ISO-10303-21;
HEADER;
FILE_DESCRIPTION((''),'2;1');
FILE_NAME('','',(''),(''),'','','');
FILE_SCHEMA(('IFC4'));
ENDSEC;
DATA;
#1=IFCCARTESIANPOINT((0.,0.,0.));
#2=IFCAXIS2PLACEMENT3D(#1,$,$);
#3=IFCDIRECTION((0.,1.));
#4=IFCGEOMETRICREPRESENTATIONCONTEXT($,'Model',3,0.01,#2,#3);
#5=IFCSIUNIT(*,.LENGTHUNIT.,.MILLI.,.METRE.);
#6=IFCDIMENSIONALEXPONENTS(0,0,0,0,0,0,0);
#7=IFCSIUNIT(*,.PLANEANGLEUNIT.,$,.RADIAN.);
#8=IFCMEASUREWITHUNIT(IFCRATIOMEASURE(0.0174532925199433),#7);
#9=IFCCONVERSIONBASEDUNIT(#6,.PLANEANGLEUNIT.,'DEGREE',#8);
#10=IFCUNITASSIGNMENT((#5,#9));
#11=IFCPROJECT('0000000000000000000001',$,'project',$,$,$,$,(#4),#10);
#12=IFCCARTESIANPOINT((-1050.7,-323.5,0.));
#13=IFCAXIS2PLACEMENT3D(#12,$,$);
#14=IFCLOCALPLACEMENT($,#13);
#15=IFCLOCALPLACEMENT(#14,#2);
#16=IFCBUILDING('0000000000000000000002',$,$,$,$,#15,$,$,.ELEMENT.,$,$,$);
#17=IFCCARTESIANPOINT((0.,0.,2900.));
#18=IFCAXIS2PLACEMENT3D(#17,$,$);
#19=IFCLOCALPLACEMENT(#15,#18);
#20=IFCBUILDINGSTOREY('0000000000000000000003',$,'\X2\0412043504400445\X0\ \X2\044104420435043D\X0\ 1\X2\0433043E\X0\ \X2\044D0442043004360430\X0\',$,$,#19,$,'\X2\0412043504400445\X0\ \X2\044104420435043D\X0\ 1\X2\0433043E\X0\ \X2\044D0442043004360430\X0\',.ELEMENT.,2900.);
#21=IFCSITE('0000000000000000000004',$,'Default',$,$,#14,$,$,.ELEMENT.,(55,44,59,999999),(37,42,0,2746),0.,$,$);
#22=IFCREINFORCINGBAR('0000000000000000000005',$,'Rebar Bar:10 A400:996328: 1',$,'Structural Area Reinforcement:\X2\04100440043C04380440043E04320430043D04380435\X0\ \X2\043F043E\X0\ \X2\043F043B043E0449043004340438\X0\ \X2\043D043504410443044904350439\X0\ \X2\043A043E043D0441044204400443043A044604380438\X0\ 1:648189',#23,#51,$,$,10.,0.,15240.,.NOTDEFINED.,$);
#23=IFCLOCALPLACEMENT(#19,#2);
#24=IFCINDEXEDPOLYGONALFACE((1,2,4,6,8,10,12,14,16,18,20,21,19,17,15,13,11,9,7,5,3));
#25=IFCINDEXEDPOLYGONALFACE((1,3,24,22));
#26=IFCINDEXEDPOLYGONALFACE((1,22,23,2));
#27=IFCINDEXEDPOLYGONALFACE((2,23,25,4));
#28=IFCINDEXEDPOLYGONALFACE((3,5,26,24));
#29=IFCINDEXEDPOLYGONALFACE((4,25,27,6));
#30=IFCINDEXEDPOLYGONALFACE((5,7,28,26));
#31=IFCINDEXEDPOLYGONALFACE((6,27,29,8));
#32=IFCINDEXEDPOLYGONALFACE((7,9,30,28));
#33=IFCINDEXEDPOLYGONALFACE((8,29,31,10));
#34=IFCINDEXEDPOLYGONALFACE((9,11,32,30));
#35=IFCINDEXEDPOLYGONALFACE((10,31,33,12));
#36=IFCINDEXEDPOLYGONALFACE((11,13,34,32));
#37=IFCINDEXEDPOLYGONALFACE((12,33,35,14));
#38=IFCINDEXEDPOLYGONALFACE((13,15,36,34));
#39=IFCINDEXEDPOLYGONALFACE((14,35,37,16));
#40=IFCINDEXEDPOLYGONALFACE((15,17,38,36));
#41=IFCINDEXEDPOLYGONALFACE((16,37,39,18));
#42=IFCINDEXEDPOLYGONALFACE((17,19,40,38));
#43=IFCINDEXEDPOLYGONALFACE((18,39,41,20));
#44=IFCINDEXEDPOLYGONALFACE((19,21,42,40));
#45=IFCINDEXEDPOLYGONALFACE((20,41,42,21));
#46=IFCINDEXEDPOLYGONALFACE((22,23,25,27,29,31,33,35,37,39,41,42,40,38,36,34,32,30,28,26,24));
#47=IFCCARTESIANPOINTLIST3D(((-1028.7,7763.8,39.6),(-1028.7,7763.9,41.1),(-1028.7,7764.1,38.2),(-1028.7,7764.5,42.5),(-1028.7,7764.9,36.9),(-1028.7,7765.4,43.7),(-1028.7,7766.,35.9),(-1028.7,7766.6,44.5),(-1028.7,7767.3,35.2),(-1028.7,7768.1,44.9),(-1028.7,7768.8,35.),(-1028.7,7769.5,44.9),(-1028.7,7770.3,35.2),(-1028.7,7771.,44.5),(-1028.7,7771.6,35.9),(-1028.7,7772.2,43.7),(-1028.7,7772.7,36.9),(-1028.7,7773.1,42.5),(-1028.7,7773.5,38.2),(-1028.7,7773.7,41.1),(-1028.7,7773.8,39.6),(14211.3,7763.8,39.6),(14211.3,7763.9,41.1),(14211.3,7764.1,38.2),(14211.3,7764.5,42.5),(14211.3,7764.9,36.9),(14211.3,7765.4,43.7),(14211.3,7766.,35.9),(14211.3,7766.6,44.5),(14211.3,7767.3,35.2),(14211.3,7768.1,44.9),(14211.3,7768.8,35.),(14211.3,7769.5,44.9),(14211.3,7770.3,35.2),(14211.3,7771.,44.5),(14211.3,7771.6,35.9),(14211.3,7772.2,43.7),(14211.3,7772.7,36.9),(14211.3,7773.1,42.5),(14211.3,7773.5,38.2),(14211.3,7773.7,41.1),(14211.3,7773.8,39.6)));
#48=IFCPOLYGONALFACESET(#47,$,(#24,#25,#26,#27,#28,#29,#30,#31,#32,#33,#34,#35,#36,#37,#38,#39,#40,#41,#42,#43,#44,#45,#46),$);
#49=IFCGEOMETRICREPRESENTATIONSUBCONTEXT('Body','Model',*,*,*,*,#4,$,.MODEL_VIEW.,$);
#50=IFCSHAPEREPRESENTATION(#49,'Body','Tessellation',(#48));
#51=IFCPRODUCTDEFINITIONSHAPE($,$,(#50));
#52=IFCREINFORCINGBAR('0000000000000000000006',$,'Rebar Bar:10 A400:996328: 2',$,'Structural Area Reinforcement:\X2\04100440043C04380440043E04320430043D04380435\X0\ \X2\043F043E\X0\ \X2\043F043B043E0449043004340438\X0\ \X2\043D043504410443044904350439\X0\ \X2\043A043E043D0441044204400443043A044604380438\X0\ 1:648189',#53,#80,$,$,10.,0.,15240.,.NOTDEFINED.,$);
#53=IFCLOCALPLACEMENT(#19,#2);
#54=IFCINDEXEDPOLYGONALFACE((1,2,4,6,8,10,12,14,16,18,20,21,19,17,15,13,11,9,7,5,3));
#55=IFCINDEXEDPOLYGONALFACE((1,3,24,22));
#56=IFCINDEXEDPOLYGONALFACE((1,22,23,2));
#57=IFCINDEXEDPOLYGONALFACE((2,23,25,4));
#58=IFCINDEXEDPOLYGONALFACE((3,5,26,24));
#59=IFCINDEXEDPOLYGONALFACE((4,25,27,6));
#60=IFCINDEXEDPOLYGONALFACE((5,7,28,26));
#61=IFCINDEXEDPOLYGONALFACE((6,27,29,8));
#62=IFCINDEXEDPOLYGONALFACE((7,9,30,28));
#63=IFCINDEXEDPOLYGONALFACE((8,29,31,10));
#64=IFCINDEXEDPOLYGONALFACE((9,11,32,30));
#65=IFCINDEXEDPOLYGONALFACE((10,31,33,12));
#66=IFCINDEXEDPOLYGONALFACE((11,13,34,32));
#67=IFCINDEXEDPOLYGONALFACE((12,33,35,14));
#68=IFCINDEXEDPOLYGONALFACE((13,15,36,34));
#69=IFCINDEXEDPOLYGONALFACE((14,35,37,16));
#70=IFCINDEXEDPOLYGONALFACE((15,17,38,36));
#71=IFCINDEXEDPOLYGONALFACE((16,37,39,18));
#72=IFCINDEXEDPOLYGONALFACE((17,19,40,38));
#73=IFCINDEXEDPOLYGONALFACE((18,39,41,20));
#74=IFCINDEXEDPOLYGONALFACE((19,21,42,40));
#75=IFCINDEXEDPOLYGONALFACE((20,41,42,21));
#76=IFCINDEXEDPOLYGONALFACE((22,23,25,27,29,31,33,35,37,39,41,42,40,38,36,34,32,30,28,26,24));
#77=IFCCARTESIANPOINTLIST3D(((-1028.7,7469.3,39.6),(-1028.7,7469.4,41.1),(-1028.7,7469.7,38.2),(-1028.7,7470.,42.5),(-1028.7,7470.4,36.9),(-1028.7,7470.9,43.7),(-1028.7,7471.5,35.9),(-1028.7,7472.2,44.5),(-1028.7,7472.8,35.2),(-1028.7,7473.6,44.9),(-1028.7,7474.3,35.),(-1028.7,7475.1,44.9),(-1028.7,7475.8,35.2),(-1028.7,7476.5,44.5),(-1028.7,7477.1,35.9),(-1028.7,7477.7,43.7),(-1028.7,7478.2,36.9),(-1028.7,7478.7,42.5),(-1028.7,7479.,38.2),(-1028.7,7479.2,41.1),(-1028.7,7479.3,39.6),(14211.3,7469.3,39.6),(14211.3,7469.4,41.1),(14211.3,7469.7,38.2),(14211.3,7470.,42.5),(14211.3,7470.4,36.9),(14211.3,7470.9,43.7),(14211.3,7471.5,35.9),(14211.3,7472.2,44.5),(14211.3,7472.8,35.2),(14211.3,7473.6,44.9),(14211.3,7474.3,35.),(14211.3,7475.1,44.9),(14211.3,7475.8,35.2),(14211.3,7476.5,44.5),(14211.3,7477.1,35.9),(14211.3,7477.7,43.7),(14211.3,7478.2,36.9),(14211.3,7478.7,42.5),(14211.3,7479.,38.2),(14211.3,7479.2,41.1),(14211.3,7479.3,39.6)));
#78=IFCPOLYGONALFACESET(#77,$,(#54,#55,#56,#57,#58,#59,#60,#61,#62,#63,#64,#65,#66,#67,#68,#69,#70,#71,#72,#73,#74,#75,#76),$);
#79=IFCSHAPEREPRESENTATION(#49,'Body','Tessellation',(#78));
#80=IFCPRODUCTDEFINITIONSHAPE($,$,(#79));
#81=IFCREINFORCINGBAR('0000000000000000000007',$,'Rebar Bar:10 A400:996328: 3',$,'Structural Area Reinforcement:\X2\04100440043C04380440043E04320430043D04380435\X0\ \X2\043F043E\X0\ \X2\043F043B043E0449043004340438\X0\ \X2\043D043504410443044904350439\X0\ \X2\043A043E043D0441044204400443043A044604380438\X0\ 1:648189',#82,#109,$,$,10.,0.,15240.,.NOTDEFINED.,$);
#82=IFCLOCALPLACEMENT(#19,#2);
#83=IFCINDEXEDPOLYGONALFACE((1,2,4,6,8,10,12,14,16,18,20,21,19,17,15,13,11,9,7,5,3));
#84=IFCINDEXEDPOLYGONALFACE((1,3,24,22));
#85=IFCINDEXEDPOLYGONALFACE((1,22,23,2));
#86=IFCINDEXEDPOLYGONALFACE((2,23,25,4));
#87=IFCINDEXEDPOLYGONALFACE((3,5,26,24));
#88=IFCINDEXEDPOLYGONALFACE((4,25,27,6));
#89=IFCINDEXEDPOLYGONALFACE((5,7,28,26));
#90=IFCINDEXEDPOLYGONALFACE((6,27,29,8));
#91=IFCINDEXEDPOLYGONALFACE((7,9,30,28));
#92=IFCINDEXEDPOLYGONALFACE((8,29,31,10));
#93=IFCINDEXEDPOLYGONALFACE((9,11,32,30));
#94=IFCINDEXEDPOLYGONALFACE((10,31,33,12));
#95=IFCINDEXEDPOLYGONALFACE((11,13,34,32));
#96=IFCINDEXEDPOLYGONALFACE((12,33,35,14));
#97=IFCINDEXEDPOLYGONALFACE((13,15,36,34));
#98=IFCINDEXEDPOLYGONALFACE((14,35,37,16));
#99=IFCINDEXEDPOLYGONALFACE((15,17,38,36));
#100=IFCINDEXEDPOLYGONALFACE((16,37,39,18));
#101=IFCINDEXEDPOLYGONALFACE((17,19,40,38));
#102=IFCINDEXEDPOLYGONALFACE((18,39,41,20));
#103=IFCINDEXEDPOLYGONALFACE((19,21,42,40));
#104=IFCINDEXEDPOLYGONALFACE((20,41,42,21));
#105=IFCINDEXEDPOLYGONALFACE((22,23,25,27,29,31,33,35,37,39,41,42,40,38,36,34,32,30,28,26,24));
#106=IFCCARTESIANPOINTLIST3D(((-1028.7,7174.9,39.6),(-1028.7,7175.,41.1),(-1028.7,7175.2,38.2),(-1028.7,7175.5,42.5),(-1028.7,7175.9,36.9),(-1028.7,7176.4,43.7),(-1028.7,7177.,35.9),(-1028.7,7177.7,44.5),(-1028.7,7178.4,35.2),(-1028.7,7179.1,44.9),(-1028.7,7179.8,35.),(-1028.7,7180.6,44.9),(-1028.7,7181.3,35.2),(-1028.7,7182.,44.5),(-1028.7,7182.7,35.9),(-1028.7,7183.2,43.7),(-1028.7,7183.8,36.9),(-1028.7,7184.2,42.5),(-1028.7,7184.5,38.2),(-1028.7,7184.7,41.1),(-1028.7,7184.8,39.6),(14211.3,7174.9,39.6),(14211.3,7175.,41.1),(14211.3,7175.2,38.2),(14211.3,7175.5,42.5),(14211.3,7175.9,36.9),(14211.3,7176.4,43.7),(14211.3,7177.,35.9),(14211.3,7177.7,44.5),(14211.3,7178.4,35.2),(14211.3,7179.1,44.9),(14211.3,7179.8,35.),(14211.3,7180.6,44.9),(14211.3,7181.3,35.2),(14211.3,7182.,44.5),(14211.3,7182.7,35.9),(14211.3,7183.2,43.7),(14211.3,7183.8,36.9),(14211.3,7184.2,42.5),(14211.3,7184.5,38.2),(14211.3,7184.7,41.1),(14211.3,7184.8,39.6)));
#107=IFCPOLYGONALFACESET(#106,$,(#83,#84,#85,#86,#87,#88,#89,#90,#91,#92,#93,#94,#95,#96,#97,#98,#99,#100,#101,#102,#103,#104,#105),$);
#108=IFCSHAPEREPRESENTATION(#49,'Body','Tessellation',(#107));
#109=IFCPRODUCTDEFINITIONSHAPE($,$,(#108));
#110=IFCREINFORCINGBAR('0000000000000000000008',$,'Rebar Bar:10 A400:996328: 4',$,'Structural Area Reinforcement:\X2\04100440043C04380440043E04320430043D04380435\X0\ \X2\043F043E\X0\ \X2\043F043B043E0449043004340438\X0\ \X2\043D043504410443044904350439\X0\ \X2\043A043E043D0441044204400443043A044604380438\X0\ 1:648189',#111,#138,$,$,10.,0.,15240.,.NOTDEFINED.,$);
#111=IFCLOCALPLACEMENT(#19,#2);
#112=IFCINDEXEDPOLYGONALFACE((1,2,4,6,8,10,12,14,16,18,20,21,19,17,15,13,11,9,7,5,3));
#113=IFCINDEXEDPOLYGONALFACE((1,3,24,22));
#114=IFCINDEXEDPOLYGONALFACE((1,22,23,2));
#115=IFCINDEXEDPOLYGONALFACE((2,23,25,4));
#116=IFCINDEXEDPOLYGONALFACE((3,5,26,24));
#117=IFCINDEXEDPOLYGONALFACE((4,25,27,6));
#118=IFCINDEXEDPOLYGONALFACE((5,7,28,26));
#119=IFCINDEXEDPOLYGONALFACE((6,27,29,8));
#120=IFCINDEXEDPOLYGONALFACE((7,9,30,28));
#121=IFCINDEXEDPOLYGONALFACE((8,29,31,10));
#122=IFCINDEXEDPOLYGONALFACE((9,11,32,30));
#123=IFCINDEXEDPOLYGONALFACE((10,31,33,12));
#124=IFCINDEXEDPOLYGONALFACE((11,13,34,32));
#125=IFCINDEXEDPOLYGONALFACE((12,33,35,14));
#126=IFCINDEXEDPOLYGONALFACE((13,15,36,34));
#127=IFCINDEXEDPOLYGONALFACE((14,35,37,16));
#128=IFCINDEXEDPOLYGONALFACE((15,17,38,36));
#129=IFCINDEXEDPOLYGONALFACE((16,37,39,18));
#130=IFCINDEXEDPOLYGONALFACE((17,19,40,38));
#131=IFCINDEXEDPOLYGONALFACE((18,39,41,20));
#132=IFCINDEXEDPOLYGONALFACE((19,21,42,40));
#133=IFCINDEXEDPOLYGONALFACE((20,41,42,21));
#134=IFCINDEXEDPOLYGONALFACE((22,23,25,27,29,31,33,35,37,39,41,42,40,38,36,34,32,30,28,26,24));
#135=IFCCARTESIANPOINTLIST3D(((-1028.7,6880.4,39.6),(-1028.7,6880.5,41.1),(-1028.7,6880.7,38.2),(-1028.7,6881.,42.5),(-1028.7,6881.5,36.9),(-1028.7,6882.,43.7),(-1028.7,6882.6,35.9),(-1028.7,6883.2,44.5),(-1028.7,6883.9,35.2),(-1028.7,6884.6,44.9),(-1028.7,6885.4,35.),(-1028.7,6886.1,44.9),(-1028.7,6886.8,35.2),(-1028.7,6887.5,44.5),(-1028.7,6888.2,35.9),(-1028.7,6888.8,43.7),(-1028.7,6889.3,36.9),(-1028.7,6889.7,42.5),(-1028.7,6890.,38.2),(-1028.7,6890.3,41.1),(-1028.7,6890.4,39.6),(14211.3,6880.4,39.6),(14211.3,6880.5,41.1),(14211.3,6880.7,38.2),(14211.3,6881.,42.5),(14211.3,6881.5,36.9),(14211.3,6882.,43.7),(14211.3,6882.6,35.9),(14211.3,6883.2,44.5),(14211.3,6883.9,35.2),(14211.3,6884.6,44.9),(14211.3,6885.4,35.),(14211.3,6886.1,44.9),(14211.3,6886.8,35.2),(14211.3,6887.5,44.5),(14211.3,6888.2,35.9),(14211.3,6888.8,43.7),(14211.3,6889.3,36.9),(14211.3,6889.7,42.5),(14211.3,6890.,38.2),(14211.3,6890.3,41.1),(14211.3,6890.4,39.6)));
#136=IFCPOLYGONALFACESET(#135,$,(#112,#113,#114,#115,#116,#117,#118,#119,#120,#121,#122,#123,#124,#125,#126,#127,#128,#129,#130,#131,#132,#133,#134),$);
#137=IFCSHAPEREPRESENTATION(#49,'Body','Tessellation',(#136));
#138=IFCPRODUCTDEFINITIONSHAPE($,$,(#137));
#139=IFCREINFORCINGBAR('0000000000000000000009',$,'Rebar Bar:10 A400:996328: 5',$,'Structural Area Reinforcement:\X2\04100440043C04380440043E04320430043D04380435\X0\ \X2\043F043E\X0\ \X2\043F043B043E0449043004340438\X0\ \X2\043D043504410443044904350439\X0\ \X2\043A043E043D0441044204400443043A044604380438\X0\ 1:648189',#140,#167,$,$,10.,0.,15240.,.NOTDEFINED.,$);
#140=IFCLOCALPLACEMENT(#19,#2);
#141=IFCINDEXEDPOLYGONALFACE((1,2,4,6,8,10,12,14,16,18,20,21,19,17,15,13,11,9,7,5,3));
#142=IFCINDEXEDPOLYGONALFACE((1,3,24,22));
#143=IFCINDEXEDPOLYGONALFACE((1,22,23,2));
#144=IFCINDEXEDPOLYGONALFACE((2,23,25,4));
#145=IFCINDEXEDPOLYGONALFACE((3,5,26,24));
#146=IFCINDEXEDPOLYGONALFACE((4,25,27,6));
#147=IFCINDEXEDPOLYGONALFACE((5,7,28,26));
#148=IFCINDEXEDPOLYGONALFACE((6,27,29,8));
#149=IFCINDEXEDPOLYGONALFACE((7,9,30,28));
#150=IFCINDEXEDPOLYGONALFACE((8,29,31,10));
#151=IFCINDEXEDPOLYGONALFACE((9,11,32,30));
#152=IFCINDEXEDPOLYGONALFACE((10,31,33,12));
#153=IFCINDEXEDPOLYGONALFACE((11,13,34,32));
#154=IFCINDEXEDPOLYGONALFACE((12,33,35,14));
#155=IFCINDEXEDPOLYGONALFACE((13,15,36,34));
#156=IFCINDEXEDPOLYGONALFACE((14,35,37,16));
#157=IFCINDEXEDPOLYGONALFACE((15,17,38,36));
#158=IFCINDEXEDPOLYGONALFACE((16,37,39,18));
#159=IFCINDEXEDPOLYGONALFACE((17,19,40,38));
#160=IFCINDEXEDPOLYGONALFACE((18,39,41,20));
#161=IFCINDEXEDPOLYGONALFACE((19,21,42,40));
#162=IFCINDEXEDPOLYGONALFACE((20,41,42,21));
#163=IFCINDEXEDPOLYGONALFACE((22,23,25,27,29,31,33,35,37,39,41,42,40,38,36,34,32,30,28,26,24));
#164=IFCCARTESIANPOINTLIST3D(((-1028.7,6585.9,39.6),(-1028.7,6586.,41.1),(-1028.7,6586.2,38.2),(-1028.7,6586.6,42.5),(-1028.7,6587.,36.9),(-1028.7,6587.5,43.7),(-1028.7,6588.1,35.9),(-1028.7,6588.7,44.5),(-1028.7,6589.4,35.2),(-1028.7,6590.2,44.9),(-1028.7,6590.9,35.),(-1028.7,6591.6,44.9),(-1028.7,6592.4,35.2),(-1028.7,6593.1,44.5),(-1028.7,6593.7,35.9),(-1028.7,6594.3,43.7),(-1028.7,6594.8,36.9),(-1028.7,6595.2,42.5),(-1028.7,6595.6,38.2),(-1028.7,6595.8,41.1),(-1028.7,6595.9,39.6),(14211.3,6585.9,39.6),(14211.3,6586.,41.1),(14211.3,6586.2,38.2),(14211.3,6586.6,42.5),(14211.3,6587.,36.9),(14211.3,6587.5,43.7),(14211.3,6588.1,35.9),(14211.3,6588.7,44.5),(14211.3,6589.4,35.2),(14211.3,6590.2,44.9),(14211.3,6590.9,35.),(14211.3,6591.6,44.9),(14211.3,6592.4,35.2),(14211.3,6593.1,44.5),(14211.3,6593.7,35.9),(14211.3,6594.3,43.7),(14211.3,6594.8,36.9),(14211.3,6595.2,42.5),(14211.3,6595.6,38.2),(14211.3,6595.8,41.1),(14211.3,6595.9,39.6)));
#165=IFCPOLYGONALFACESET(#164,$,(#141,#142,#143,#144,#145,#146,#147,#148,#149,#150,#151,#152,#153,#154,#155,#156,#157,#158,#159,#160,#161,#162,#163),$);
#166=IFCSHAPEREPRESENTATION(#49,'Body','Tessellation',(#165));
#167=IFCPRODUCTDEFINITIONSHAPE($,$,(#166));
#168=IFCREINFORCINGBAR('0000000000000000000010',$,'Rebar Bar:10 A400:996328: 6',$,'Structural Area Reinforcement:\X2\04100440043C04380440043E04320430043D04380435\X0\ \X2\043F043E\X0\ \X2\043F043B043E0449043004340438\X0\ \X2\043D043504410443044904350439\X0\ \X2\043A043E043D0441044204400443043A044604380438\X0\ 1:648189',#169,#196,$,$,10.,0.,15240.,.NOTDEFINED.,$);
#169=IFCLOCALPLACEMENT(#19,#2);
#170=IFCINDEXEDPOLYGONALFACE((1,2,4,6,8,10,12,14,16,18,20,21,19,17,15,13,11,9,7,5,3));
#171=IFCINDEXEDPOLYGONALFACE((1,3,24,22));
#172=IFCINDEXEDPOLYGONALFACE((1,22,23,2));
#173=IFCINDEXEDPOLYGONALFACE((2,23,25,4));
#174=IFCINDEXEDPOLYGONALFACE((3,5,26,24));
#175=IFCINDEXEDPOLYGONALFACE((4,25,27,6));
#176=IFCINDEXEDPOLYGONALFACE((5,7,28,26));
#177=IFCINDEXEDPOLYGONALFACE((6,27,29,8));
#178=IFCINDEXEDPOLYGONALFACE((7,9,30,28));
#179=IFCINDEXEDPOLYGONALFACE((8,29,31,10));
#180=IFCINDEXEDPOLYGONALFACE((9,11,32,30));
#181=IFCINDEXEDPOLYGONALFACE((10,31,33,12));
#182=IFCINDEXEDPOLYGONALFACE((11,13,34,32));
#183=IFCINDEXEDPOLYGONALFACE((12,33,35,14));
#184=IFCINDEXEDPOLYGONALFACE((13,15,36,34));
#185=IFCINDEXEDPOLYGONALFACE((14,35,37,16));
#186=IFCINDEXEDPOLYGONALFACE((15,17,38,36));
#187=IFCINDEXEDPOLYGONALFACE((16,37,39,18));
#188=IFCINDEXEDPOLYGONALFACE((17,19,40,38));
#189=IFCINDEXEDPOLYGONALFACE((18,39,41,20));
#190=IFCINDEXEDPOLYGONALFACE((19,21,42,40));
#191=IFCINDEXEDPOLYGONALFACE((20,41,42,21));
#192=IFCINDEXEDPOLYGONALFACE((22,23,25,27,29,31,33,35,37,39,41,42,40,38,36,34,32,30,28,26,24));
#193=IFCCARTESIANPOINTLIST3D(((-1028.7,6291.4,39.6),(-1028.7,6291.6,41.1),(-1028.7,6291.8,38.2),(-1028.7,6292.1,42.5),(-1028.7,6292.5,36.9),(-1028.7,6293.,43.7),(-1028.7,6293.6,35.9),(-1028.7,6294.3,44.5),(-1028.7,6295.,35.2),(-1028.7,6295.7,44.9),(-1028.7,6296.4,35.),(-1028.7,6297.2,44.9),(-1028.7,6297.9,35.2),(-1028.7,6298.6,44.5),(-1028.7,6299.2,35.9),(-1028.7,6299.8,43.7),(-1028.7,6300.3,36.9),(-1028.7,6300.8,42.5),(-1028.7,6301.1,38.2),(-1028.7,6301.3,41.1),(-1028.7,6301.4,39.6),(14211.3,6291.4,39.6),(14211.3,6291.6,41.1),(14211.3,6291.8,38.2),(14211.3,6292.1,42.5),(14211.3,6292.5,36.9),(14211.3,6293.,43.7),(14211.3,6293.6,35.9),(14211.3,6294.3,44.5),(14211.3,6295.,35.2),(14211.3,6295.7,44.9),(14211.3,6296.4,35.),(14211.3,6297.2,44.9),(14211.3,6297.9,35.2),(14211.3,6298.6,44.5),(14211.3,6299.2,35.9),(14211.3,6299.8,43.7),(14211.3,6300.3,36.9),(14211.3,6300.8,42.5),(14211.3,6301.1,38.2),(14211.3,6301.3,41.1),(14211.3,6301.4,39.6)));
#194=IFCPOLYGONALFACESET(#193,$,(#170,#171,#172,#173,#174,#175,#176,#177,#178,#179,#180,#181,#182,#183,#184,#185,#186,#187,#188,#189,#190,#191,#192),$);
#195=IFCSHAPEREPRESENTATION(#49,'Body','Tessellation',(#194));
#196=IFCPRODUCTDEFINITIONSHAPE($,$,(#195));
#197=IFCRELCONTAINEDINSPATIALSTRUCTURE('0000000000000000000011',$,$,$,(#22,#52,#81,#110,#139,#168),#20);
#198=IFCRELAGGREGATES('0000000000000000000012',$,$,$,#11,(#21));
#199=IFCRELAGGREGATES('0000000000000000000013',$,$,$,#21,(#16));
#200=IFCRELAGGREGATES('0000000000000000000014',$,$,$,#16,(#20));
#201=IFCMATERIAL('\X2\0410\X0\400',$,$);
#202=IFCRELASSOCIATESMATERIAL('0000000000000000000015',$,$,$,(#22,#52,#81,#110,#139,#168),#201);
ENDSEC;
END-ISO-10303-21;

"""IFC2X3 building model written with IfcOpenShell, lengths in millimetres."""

from ifc_helpers import new_model, entity, si_unit, converted_unit, direction, frame, origin, place, context, subcontext, project, spatial, material, element, save


model = new_model("IFC2X3")

# Units and contexts
model_context = context("Model", 3, precision=0.01, world=origin(), true_north=direction((0.0, 1.0)))
body_context = subcontext(model_context, "Body", "Model", "MODEL_VIEW")
ifc_project = project(units=[si_unit("LENGTHUNIT", "METRE", prefix="MILLI"), converted_unit("PLANEANGLEUNIT", "DEGREE", entity("IfcRatioMeasure", 0.0174532925199433), si_unit("PLANEANGLEUNIT", "RADIAN"), dimensions=[0, 0, 0, 0, 0, 0, 0])], contexts=[model_context])

# Site, building, storey
site_placement = place(None, frame((-1050.7, -323.5, 0.0)))
site = spatial("IfcSite", under=ifc_project, at=site_placement, Name="Default", CompositionType="ELEMENT", RefLatitude=(55, 44, 59, 999999), RefLongitude=(37, 42, 0, 2746), RefElevation=0.0)
building_placement = place(site_placement, origin())
building = spatial("IfcBuilding", under=site, at=building_placement, CompositionType="ELEMENT")
storey_placement = place(building_placement, frame((0.0, 0.0, 2900.0)))
storey = spatial("IfcBuildingStorey", under=building, at=storey_placement, Name="Верх стен 1го этажа", LongName="Верх стен 1го этажа", CompositionType="ELEMENT", Elevation=2900.0)

# Reinforcing bars
ifc_material = material(Name="А400")
reinforcing_bar_1_placement = place(storey_placement, origin())
element("IfcReinforcingBar", 1, at=reinforcing_bar_1_placement, inside=storey, material=ifc_material, Name="Rebar Bar:10 A400:996328: 1", ObjectType="Structural Area Reinforcement:Армирование по площади несущей конструкции 1:648189", BarLength=15240.0, BarRole="NOTDEFINED", CrossSectionArea=0.0, NominalDiameter=10.0, context=body_context, shape_type="AdvancedSweptSolid", body=[
    entity("IfcSweptDiskSolid", entity("IfcCompositeCurve", [entity("IfcCompositeCurveSegment", "CONTINUOUS", True, entity("IfcPolyline", [entity("IfcCartesianPoint", [14211.3, 7768.8, 40.0]), entity("IfcCartesianPoint", [-1028.7, 7768.8, 40.0])]))], False), 5.0, None, 0.0, 1.0),
])
reinforcing_bar_2_placement = place(storey_placement, origin())
element("IfcReinforcingBar", 2, at=reinforcing_bar_2_placement, inside=storey, material=ifc_material, Name="Rebar Bar:10 A400:996328: 2", ObjectType="Structural Area Reinforcement:Армирование по площади несущей конструкции 1:648189", BarLength=15240.0, BarRole="NOTDEFINED", CrossSectionArea=0.0, NominalDiameter=10.0, context=body_context, shape_type="AdvancedSweptSolid", body=[
    entity("IfcSweptDiskSolid", entity("IfcCompositeCurve", [entity("IfcCompositeCurveSegment", "CONTINUOUS", True, entity("IfcPolyline", [entity("IfcCartesianPoint", [14211.3, 7474.3, 40.0]), entity("IfcCartesianPoint", [-1028.7, 7474.3, 40.0])]))], False), 5.0, None, 0.0, 1.0),
])
reinforcing_bar_3_placement = place(storey_placement, origin())
element("IfcReinforcingBar", 3, at=reinforcing_bar_3_placement, inside=storey, material=ifc_material, Name="Rebar Bar:10 A400:996328: 3", ObjectType="Structural Area Reinforcement:Армирование по площади несущей конструкции 1:648189", BarLength=15240.0, BarRole="NOTDEFINED", CrossSectionArea=0.0, NominalDiameter=10.0, context=body_context, shape_type="AdvancedSweptSolid", body=[
    entity("IfcSweptDiskSolid", entity("IfcCompositeCurve", [entity("IfcCompositeCurveSegment", "CONTINUOUS", True, entity("IfcPolyline", [entity("IfcCartesianPoint", [14211.3, 7179.8, 40.0]), entity("IfcCartesianPoint", [-1028.7, 7179.8, 40.0])]))], False), 5.0, None, 0.0, 1.0),
])
reinforcing_bar_4_placement = place(storey_placement, origin())
element("IfcReinforcingBar", 4, at=reinforcing_bar_4_placement, inside=storey, material=ifc_material, Name="Rebar Bar:10 A400:996328: 4", ObjectType="Structural Area Reinforcement:Армирование по площади несущей конструкции 1:648189", BarLength=15240.0, BarRole="NOTDEFINED", CrossSectionArea=0.0, NominalDiameter=10.0, context=body_context, shape_type="AdvancedSweptSolid", body=[
    entity("IfcSweptDiskSolid", entity("IfcCompositeCurve", [entity("IfcCompositeCurveSegment", "CONTINUOUS", True, entity("IfcPolyline", [entity("IfcCartesianPoint", [14211.3, 6885.4, 40.0]), entity("IfcCartesianPoint", [-1028.7, 6885.4, 40.0])]))], False), 5.0, None, 0.0, 1.0),
])
reinforcing_bar_5_placement = place(storey_placement, origin())
element("IfcReinforcingBar", 5, at=reinforcing_bar_5_placement, inside=storey, material=ifc_material, Name="Rebar Bar:10 A400:996328: 5", ObjectType="Structural Area Reinforcement:Армирование по площади несущей конструкции 1:648189", BarLength=15240.0, BarRole="NOTDEFINED", CrossSectionArea=0.0, NominalDiameter=10.0, context=body_context, shape_type="AdvancedSweptSolid", body=[
    entity("IfcSweptDiskSolid", entity("IfcCompositeCurve", [entity("IfcCompositeCurveSegment", "CONTINUOUS", True, entity("IfcPolyline", [entity("IfcCartesianPoint", [14211.3, 6590.9, 40.0]), entity("IfcCartesianPoint", [-1028.7, 6590.9, 40.0])]))], False), 5.0, None, 0.0, 1.0),
])
reinforcing_bar_6_placement = place(storey_placement, origin())
element("IfcReinforcingBar", 6, at=reinforcing_bar_6_placement, inside=storey, material=ifc_material, Name="Rebar Bar:10 A400:996328: 6", ObjectType="Structural Area Reinforcement:Армирование по площади несущей конструкции 1:648189", BarLength=15240.0, BarRole="NOTDEFINED", CrossSectionArea=0.0, NominalDiameter=10.0, context=body_context, shape_type="AdvancedSweptSolid", body=[
    entity("IfcSweptDiskSolid", entity("IfcCompositeCurve", [entity("IfcCompositeCurveSegment", "CONTINUOUS", True, entity("IfcPolyline", [entity("IfcCartesianPoint", [14211.3, 6296.4, 40.0]), entity("IfcCartesianPoint", [-1028.7, 6296.4, 40.0])]))], False), 5.0, None, 0.0, 1.0),
])

save(model, "model.ifc")
